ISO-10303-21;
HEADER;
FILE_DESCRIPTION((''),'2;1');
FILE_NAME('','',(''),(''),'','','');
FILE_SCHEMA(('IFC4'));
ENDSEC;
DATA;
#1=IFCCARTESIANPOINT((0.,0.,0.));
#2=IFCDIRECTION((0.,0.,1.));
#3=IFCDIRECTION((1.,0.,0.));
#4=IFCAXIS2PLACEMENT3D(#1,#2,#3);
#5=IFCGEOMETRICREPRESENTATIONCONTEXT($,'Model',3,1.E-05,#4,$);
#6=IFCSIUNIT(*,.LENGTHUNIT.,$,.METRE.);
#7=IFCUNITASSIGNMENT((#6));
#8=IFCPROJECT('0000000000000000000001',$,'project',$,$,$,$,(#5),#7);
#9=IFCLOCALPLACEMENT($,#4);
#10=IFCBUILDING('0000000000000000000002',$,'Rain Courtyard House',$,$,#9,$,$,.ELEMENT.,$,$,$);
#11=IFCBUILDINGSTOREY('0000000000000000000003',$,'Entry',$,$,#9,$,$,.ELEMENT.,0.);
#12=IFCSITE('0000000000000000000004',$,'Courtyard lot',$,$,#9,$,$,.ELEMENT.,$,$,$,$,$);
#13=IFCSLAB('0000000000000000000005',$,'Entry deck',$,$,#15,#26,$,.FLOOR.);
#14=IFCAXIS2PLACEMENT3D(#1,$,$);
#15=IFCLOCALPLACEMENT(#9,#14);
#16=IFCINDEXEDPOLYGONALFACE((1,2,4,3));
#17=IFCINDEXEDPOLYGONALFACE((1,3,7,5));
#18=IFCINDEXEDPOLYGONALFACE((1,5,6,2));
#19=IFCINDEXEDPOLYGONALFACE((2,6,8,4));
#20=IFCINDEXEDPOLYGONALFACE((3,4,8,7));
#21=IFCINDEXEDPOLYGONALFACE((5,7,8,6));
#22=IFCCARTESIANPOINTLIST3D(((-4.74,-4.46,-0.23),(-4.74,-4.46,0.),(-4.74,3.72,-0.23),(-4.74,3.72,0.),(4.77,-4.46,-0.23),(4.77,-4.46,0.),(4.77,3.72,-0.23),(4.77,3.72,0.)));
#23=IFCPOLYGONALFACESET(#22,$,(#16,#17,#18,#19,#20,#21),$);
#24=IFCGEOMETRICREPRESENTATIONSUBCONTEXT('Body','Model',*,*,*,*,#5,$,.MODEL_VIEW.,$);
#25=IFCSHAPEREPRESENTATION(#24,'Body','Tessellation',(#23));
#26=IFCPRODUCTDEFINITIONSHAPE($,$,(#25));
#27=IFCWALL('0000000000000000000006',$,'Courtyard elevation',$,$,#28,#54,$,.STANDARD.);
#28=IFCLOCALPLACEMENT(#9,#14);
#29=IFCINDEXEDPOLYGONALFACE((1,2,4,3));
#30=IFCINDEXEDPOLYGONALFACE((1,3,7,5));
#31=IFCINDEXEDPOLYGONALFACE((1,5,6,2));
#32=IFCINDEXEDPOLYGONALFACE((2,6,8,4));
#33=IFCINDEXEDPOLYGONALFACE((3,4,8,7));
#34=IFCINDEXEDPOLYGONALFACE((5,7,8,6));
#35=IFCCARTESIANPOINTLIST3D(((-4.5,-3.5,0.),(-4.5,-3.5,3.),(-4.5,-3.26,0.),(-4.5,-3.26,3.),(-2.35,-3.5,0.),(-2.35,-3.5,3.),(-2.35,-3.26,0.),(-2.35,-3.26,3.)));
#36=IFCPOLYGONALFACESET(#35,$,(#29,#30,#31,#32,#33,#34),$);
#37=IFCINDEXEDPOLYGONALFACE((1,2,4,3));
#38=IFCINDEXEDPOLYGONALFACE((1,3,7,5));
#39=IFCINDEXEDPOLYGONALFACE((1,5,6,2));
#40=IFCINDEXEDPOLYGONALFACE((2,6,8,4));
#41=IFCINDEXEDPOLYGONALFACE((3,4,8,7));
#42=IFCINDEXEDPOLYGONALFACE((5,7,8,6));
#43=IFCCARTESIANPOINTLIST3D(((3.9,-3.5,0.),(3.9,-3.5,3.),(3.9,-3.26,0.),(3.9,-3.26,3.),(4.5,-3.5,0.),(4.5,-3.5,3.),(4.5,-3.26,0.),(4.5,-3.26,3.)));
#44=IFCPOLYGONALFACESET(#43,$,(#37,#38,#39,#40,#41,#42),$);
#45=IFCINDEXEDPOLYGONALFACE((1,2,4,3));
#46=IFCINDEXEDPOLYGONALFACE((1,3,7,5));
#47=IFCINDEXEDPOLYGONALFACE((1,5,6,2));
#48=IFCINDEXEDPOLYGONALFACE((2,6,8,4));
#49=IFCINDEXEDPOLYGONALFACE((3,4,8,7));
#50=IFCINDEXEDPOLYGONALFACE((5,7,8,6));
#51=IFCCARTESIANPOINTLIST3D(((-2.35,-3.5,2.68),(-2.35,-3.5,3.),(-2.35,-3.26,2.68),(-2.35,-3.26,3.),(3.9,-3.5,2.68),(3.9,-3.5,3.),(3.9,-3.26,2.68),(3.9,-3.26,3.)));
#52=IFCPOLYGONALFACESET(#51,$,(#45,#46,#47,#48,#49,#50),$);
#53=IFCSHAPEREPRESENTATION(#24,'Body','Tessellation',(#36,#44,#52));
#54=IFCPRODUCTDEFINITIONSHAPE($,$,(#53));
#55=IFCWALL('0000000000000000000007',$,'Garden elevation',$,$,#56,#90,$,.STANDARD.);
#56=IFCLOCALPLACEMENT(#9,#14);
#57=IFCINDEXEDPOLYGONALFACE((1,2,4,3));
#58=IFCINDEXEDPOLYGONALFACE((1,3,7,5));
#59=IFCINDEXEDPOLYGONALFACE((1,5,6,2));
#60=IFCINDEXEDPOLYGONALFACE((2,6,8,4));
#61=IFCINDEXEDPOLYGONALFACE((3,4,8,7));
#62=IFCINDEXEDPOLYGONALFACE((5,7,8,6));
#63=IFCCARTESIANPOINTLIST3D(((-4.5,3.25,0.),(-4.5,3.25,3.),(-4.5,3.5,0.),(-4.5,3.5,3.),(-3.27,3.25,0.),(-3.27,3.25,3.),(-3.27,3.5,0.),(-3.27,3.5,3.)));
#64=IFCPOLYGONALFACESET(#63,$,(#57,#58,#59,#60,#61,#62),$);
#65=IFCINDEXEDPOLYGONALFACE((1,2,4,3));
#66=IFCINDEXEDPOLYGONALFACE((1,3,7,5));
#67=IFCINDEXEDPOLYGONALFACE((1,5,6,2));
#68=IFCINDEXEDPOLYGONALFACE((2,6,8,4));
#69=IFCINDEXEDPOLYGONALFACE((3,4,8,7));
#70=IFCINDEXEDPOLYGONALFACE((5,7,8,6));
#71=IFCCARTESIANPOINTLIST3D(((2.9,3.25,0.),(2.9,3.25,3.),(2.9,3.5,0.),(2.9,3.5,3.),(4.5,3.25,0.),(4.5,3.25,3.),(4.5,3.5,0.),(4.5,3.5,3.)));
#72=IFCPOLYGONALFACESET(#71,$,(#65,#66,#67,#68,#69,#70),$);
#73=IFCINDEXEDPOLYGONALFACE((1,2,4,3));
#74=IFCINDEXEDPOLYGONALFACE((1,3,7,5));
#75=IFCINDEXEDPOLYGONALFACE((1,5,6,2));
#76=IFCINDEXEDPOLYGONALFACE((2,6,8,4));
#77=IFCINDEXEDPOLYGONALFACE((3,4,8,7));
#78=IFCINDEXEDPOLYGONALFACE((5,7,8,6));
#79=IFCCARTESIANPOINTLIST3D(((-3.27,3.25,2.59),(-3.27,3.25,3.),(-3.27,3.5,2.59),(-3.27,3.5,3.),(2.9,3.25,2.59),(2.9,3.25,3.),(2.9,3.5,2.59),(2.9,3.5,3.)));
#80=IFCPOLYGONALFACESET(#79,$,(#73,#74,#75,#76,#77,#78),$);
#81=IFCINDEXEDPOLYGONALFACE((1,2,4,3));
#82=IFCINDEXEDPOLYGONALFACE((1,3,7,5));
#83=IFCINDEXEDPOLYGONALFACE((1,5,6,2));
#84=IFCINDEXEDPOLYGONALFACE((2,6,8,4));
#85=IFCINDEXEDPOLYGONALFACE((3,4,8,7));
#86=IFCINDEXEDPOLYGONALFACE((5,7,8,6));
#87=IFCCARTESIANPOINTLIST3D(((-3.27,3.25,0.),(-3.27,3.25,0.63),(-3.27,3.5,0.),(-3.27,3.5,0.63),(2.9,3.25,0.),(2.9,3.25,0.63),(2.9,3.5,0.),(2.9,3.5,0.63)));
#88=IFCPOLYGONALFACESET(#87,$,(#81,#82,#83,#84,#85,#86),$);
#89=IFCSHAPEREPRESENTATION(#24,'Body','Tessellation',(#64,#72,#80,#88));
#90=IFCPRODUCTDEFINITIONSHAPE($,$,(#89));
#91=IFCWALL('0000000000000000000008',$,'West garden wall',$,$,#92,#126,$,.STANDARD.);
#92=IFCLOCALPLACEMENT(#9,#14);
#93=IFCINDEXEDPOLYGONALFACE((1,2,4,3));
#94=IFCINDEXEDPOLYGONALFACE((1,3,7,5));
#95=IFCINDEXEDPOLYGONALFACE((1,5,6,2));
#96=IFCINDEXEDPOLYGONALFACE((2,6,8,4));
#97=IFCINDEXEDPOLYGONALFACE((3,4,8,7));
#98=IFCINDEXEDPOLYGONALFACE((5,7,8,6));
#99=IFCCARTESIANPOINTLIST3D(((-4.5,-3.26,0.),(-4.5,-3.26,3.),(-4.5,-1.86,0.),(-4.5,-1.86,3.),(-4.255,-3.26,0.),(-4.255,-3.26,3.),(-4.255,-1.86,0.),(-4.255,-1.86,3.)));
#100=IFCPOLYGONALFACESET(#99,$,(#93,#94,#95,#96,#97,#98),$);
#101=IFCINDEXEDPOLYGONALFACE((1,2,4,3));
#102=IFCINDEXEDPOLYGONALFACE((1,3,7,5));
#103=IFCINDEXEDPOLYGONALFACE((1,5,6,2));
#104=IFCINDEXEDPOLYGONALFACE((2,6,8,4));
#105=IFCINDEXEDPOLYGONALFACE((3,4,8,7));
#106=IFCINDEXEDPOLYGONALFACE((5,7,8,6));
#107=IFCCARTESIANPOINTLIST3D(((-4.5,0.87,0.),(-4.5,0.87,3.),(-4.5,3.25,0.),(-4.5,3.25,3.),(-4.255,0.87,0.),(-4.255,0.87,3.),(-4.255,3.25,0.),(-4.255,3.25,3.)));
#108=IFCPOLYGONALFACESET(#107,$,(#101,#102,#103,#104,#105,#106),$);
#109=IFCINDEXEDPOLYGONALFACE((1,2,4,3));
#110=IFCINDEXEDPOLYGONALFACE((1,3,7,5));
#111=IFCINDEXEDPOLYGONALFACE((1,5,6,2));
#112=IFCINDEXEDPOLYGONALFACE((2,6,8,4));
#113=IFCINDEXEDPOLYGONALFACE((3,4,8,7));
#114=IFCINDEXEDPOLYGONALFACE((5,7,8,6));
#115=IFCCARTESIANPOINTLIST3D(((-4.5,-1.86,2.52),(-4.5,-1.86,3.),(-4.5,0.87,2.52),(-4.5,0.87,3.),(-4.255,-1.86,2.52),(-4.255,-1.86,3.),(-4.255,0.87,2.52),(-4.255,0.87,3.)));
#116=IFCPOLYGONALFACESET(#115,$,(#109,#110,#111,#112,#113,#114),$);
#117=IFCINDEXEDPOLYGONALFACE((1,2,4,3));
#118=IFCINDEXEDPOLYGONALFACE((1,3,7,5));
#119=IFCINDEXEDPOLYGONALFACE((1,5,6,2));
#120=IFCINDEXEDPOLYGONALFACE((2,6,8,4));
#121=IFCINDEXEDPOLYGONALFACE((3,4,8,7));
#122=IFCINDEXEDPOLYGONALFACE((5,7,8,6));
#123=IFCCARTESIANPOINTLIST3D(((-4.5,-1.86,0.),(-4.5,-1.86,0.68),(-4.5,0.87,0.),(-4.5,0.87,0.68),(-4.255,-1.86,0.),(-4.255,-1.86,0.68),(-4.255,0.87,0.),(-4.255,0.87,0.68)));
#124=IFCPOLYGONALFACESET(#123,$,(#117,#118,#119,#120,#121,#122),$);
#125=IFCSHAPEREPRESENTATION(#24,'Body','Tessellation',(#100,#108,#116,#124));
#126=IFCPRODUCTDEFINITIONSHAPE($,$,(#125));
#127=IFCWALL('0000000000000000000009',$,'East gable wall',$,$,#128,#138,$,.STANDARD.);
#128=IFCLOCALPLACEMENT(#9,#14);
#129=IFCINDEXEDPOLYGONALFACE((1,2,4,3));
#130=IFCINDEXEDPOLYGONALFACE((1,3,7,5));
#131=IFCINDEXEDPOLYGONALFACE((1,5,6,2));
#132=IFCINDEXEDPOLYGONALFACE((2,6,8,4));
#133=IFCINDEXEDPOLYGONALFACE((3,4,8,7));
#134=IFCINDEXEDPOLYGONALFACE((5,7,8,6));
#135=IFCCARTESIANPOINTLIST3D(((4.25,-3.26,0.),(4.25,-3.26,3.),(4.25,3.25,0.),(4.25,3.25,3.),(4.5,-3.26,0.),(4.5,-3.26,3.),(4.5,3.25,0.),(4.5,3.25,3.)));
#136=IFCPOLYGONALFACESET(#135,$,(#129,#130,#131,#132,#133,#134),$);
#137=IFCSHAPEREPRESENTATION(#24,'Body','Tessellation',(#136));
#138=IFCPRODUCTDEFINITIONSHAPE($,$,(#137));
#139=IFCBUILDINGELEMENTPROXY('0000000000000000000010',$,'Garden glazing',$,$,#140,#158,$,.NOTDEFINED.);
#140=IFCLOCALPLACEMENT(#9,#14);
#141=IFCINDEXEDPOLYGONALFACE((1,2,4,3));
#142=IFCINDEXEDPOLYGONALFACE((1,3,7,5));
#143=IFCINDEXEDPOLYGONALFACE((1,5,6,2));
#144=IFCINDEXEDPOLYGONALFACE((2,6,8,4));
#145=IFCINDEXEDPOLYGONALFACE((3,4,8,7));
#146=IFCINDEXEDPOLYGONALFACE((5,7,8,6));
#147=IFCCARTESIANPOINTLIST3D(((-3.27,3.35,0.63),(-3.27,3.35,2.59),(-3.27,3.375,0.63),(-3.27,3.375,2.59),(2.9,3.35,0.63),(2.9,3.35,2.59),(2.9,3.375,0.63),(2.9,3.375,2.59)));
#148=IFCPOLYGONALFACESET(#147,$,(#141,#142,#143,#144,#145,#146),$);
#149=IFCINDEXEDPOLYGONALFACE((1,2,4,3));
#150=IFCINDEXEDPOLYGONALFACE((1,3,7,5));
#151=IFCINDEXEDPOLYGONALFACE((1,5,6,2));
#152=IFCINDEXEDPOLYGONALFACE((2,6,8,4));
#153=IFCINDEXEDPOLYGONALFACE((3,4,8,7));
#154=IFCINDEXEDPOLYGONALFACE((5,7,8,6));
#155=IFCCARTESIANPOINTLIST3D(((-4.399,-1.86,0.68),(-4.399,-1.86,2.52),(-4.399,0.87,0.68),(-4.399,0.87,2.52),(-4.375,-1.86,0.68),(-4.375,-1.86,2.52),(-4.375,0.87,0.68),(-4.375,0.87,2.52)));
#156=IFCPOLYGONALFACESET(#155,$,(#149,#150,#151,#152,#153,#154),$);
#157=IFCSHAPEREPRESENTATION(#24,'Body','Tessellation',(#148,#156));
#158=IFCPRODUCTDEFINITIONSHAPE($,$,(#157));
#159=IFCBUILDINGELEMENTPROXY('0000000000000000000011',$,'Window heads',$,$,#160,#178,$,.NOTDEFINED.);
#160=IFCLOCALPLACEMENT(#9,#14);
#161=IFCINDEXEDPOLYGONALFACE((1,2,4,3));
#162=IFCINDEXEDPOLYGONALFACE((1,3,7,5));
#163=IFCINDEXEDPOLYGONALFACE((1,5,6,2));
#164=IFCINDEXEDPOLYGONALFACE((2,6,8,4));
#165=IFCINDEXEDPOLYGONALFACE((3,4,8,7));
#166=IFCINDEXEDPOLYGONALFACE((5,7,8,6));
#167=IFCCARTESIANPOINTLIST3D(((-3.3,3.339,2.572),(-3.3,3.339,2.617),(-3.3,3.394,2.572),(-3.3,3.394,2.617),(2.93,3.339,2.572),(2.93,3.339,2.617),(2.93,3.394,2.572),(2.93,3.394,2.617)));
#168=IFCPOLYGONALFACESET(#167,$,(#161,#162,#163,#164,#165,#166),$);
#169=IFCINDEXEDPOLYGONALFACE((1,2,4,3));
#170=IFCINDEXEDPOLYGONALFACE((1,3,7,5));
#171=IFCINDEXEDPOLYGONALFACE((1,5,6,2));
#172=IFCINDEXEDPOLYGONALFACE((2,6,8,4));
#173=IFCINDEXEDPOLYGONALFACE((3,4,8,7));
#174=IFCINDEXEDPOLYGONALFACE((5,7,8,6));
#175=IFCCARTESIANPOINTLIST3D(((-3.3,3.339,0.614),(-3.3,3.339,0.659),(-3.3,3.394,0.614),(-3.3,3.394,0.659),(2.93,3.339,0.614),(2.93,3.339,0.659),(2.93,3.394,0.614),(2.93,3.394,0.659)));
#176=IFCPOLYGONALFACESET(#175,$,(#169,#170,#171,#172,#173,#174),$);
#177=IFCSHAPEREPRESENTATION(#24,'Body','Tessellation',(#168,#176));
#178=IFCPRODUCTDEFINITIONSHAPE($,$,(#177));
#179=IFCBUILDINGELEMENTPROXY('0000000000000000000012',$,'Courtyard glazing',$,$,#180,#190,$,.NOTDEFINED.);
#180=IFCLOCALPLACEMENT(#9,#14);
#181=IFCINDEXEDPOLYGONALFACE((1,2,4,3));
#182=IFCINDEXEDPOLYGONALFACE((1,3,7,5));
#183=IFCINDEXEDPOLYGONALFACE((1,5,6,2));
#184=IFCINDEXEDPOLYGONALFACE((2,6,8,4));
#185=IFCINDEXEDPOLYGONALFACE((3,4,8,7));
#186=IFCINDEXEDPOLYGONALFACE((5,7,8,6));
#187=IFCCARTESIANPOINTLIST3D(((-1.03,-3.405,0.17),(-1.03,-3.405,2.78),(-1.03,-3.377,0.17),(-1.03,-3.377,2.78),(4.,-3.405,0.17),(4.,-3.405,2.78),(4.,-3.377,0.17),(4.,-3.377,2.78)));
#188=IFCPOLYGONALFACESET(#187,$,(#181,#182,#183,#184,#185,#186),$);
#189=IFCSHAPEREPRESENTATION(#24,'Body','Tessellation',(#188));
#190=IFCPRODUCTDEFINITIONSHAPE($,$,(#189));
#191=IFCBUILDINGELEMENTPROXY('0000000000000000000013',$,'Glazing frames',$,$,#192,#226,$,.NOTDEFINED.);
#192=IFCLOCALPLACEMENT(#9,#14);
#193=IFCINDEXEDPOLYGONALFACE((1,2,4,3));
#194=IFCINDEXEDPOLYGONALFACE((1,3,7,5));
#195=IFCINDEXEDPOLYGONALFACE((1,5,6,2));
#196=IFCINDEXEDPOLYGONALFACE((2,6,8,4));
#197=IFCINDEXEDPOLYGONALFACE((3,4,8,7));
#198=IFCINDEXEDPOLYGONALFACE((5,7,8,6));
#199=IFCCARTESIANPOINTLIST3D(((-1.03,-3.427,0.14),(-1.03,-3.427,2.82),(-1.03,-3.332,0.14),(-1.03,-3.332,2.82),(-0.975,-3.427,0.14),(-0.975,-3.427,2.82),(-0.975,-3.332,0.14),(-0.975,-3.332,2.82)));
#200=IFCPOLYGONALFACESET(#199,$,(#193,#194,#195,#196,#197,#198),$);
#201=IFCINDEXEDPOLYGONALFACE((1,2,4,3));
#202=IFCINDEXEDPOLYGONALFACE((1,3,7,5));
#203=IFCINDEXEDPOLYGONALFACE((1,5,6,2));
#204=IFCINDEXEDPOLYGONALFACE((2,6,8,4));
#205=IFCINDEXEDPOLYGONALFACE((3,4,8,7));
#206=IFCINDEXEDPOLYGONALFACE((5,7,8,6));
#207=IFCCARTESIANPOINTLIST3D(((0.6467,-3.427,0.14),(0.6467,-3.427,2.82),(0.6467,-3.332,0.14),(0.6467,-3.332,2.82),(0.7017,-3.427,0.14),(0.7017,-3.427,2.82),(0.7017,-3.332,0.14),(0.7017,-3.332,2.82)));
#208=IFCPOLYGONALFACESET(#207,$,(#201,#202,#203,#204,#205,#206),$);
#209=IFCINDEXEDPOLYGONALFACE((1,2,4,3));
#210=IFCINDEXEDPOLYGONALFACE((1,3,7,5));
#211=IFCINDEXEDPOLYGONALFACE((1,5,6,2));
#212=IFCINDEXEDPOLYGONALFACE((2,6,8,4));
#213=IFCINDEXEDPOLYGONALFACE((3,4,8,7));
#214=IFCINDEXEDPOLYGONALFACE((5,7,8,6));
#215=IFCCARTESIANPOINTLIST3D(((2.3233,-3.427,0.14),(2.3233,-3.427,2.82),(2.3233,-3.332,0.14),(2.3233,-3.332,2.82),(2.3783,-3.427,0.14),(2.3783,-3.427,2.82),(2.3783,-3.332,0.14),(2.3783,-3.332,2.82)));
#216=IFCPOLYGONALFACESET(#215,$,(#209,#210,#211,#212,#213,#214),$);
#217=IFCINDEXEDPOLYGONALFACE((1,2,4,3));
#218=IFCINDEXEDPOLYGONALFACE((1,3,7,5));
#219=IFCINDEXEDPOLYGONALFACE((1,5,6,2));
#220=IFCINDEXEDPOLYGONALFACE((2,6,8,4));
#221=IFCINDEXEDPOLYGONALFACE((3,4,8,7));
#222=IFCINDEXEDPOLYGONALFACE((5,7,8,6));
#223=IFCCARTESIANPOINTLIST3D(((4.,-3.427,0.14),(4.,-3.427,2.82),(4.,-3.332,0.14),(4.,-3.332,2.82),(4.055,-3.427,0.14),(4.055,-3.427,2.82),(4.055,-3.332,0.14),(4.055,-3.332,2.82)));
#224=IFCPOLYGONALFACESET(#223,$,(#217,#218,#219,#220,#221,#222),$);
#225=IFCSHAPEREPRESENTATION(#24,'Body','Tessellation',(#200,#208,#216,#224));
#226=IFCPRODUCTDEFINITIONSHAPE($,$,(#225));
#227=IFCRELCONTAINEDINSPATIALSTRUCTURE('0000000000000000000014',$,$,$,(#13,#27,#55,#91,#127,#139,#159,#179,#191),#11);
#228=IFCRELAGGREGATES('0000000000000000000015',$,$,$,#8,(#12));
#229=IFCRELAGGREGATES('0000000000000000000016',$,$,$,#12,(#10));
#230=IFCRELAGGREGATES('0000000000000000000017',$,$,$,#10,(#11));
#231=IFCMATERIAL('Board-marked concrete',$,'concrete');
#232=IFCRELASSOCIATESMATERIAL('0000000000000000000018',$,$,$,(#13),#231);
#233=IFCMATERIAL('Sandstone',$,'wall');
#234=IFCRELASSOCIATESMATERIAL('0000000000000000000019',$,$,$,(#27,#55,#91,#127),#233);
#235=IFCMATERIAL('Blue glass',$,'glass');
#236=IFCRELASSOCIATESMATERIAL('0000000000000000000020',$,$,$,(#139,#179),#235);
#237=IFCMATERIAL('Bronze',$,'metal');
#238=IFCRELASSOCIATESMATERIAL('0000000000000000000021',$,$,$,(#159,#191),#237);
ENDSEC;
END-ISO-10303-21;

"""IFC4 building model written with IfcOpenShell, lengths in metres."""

from ifc_helpers import new_model, si_unit, frame, origin_with_axes, origin_2d, place, context, subcontext, project, spatial, rectangle, extrude, material, element, save


model = new_model("IFC4")

# Units and contexts
model_context = context("Model", 3, precision=1e-05, world=origin_with_axes())
body_context = subcontext(model_context, "Body", "Model", "MODEL_VIEW")
ifc_project = project(units=[si_unit("LENGTHUNIT", "METRE")], contexts=[model_context])

# Site, building, storey
placement = place(None, origin_with_axes())
site = spatial("IfcSite", under=ifc_project, at=placement, Name="Courtyard lot", CompositionType="ELEMENT")
building = spatial("IfcBuilding", under=site, at=placement, Name="Rain Courtyard House", CompositionType="ELEMENT")
storey = spatial("IfcBuildingStorey", under=building, at=placement, Name="Entry", CompositionType="ELEMENT", Elevation=0.0)

# Slab
ifc_material_1 = material(Name="Board-marked concrete", Category="concrete")
element("IfcSlab", 1, at=placement, inside=storey, material=ifc_material_1, Name="Entry deck", PredefinedType="FLOOR", context=body_context, shape_type="SweptSolid", body=[
    extrude(rectangle(XDim=9.51, YDim=8.18, at=origin_2d()), frame((0.015, -0.37, -0.23), z_axis=(0.0, 0.0, 1.0), x_axis=(1.0, 0.0, 0.0)), (0.0, 0.0, 1.0), 0.23),
])

# Walls
ifc_material_2 = material(Name="Sandstone", Category="wall")
element("IfcWall", 2, at=placement, inside=storey, material=ifc_material_2, Name="Courtyard elevation", PredefinedType="STANDARD", context=body_context, shape_type="SweptSolid", body=[
    extrude(rectangle(XDim=2.15, YDim=0.24, at=origin_2d()), frame((-3.425, -3.38, 0.0), z_axis=(0.0, 0.0, 1.0), x_axis=(1.0, 0.0, 0.0)), (0.0, 0.0, 1.0), 3.0),
    extrude(rectangle(XDim=0.6, YDim=0.24, at=origin_2d()), frame((4.2, -3.38, 0.0), z_axis=(0.0, 0.0, 1.0), x_axis=(1.0, 0.0, 0.0)), (0.0, 0.0, 1.0), 3.0),
    extrude(rectangle(XDim=6.25, YDim=0.24, at=origin_2d()), frame((0.775, -3.38, 2.68), z_axis=(0.0, 0.0, 1.0), x_axis=(1.0, 0.0, 0.0)), (0.0, 0.0, 1.0), 0.32),
])
element("IfcWall", 3, at=placement, inside=storey, material=ifc_material_2, Name="Garden elevation", PredefinedType="STANDARD", context=body_context, shape_type="SweptSolid", body=[
    extrude(rectangle(XDim=1.23, YDim=0.25, at=origin_2d()), frame((-3.885, 3.375, 0.0), z_axis=(0.0, 0.0, 1.0), x_axis=(1.0, 0.0, 0.0)), (0.0, 0.0, 1.0), 3.0),
    extrude(rectangle(XDim=1.6, YDim=0.25, at=origin_2d()), frame((3.7, 3.375, 0.0), z_axis=(0.0, 0.0, 1.0), x_axis=(1.0, 0.0, 0.0)), (0.0, 0.0, 1.0), 3.0),
    extrude(rectangle(XDim=6.17, YDim=0.25, at=origin_2d()), frame((-0.185, 3.375, 2.59), z_axis=(0.0, 0.0, 1.0), x_axis=(1.0, 0.0, 0.0)), (0.0, 0.0, 1.0), 0.41),
    extrude(rectangle(XDim=6.17, YDim=0.25, at=origin_2d()), frame((-0.185, 3.375, 0.0), z_axis=(0.0, 0.0, 1.0), x_axis=(1.0, 0.0, 0.0)), (0.0, 0.0, 1.0), 0.63),
])
element("IfcWall", 4, at=placement, inside=storey, material=ifc_material_2, Name="West garden wall", PredefinedType="STANDARD", context=body_context, shape_type="SweptSolid", body=[
    extrude(rectangle(XDim=0.245, YDim=1.4, at=origin_2d()), frame((-4.3775, -2.56, 0.0), z_axis=(0.0, 0.0, 1.0), x_axis=(1.0, 0.0, 0.0)), (0.0, 0.0, 1.0), 3.0),
    extrude(rectangle(XDim=0.245, YDim=2.38, at=origin_2d()), frame((-4.3775, 2.06, 0.0), z_axis=(0.0, 0.0, 1.0), x_axis=(1.0, 0.0, 0.0)), (0.0, 0.0, 1.0), 3.0),
    extrude(rectangle(XDim=0.245, YDim=2.73, at=origin_2d()), frame((-4.3775, -0.495, 2.52), z_axis=(0.0, 0.0, 1.0), x_axis=(1.0, 0.0, 0.0)), (0.0, 0.0, 1.0), 0.48),
    extrude(rectangle(XDim=0.245, YDim=2.73, at=origin_2d()), frame((-4.3775, -0.495, 0.0), z_axis=(0.0, 0.0, 1.0), x_axis=(1.0, 0.0, 0.0)), (0.0, 0.0, 1.0), 0.68),
])
element("IfcWall", 5, at=placement, inside=storey, material=ifc_material_2, Name="East gable wall", PredefinedType="STANDARD", context=body_context, shape_type="SweptSolid", body=[
    extrude(rectangle(XDim=0.25, YDim=6.51, at=origin_2d()), frame((4.375, -0.005, 0.0), z_axis=(0.0, 0.0, 1.0), x_axis=(1.0, 0.0, 0.0)), (0.0, 0.0, 1.0), 3.0),
])

# Building element proxies
ifc_material_3 = material(Name="Blue glass", Category="glass")
element("IfcBuildingElementProxy", 6, at=placement, inside=storey, material=ifc_material_3, Name="Garden glazing", PredefinedType="NOTDEFINED", context=body_context, shape_type="SweptSolid", body=[
    extrude(rectangle(XDim=6.17, YDim=0.025, at=origin_2d()), frame((-0.185, 3.3625, 0.63), z_axis=(0.0, 0.0, 1.0), x_axis=(1.0, 0.0, 0.0)), (0.0, 0.0, 1.0), 1.96),
    extrude(rectangle(XDim=0.024, YDim=2.73, at=origin_2d()), frame((-4.387, -0.495, 0.68), z_axis=(0.0, 0.0, 1.0), x_axis=(1.0, 0.0, 0.0)), (0.0, 0.0, 1.0), 1.84),
])
ifc_material_4 = material(Name="Bronze", Category="metal")
element("IfcBuildingElementProxy", 7, at=placement, inside=storey, material=ifc_material_4, Name="Window heads", PredefinedType="NOTDEFINED", context=body_context, shape_type="SweptSolid", body=[
    extrude(rectangle(XDim=6.23, YDim=0.055, at=origin_2d()), frame((-0.185, 3.3665, 2.572), z_axis=(0.0, 0.0, 1.0), x_axis=(1.0, 0.0, 0.0)), (0.0, 0.0, 1.0), 0.045),
    extrude(rectangle(XDim=6.23, YDim=0.055, at=origin_2d()), frame((-0.185, 3.3665, 0.614), z_axis=(0.0, 0.0, 1.0), x_axis=(1.0, 0.0, 0.0)), (0.0, 0.0, 1.0), 0.045),
])
element("IfcBuildingElementProxy", 8, at=placement, inside=storey, material=ifc_material_3, Name="Courtyard glazing", PredefinedType="NOTDEFINED", context=body_context, shape_type="SweptSolid", body=[
    extrude(rectangle(XDim=5.03, YDim=0.028, at=origin_2d()), frame((1.485, -3.391, 0.17), z_axis=(0.0, 0.0, 1.0), x_axis=(1.0, 0.0, 0.0)), (0.0, 0.0, 1.0), 2.61),
])
element("IfcBuildingElementProxy", 9, at=placement, inside=storey, material=ifc_material_4, Name="Glazing frames", PredefinedType="NOTDEFINED", context=body_context, shape_type="SweptSolid", body=[
    extrude(rectangle(XDim=0.055, YDim=0.095, at=origin_2d()), frame((-1.0025, -3.3795, 0.14), z_axis=(0.0, 0.0, 1.0), x_axis=(1.0, 0.0, 0.0)), (0.0, 0.0, 1.0), 2.68),
    extrude(rectangle(XDim=0.055, YDim=0.095, at=origin_2d()), frame((0.6742, -3.3795, 0.14), z_axis=(0.0, 0.0, 1.0), x_axis=(1.0, 0.0, 0.0)), (0.0, 0.0, 1.0), 2.68),
    extrude(rectangle(XDim=0.055, YDim=0.095, at=origin_2d()), frame((2.3508, -3.3795, 0.14), z_axis=(0.0, 0.0, 1.0), x_axis=(1.0, 0.0, 0.0)), (0.0, 0.0, 1.0), 2.68),
    extrude(rectangle(XDim=0.055, YDim=0.095, at=origin_2d()), frame((4.0275, -3.3795, 0.14), z_axis=(0.0, 0.0, 1.0), x_axis=(1.0, 0.0, 0.0)), (0.0, 0.0, 1.0), 2.68),
])

save(model, "model.ifc")
